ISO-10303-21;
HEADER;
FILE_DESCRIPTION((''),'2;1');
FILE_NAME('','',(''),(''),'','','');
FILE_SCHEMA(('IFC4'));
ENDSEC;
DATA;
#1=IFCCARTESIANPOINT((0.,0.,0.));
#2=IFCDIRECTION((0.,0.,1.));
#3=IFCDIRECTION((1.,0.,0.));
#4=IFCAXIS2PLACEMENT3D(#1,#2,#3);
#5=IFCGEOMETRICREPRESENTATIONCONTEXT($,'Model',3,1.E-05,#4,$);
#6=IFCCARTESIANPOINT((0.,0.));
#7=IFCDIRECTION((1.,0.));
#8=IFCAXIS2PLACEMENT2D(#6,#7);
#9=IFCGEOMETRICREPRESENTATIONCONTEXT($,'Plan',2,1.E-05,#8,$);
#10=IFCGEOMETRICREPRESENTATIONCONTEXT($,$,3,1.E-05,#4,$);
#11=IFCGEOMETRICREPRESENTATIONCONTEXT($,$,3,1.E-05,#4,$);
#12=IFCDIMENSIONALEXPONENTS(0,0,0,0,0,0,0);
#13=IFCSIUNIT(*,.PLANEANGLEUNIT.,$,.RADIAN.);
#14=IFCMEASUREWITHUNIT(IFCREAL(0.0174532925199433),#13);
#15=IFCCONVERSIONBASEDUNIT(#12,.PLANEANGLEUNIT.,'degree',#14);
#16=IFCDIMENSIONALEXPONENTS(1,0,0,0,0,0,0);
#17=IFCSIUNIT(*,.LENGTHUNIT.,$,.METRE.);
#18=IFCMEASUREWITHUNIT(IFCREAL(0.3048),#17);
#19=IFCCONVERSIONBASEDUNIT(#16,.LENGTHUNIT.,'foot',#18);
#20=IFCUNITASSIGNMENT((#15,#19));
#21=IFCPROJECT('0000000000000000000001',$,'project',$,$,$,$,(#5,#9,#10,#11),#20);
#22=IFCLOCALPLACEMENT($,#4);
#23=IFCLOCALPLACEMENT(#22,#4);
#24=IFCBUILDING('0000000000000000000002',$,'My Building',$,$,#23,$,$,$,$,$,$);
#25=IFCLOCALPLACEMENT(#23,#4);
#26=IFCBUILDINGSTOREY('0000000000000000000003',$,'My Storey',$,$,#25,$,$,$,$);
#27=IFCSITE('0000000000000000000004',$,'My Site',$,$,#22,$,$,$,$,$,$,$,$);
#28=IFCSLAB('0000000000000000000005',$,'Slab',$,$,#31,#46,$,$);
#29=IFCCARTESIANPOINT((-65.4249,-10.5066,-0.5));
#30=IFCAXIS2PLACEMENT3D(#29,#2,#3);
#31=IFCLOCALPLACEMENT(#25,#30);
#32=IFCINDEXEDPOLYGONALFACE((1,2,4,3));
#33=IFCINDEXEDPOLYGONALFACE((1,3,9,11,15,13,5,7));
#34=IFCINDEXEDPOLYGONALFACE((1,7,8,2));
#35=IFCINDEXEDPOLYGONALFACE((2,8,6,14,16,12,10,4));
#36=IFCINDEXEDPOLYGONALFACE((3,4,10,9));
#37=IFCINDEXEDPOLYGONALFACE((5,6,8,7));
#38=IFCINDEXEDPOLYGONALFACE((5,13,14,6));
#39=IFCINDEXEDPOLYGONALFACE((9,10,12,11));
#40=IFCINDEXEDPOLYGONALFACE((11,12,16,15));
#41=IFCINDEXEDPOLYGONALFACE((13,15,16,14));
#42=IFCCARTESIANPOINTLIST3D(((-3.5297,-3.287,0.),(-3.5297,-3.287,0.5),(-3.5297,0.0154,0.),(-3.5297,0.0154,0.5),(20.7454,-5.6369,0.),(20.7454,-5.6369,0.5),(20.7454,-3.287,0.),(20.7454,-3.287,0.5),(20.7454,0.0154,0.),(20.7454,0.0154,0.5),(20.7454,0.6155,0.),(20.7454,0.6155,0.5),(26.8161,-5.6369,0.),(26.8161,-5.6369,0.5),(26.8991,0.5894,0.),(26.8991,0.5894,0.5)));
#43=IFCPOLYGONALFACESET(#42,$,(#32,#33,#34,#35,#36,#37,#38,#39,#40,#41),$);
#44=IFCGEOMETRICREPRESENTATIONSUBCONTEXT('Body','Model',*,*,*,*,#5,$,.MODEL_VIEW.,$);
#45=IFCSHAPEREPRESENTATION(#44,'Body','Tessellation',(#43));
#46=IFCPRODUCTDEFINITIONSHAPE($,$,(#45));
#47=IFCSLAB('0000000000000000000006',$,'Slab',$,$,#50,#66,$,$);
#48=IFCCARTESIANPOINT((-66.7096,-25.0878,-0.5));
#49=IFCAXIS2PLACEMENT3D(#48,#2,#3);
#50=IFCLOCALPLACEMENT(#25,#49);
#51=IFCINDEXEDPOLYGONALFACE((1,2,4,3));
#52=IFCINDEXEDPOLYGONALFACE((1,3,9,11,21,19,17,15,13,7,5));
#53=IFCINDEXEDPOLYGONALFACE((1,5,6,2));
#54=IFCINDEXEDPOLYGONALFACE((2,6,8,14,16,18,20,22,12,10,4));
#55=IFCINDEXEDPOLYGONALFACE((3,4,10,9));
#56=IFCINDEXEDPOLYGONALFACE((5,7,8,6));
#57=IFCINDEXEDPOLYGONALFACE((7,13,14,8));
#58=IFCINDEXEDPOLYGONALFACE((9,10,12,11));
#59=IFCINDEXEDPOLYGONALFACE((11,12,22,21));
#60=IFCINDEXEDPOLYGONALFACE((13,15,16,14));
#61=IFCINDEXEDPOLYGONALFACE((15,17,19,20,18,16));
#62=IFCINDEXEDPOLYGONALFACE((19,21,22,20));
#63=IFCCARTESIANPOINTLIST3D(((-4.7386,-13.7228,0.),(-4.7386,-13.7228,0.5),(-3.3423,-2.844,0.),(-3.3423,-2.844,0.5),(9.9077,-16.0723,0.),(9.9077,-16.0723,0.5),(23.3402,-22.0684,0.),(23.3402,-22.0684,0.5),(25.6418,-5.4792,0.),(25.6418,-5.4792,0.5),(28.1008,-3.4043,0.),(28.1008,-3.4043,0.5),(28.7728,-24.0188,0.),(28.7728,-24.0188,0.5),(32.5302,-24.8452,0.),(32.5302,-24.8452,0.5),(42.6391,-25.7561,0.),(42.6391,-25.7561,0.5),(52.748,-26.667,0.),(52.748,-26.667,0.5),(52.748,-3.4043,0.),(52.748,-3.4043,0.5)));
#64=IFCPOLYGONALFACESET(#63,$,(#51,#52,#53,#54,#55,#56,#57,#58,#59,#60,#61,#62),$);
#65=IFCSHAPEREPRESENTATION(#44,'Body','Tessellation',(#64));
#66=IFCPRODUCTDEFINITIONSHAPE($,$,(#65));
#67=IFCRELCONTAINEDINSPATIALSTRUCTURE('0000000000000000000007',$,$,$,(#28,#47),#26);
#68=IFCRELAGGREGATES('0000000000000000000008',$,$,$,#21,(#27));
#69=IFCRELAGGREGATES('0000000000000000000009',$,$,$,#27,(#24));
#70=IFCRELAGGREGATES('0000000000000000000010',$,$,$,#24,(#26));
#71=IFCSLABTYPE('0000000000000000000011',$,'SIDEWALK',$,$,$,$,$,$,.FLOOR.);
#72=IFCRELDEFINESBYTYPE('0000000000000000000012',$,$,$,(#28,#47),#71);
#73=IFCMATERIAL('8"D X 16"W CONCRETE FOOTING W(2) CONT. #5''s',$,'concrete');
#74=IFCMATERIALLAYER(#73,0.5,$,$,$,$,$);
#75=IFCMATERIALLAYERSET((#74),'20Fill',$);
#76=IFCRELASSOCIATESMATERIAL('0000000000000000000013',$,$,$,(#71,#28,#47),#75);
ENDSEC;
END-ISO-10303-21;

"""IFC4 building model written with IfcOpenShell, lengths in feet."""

from ifc_helpers import new_model, entity, si_unit, converted_unit, frame, origin_with_axes, origin_2d_with_axis, place, context, subcontext, project, spatial, line, indexed_curve, outline, extrude, material, layer, layer_set, layer_usage, type_object, element, save


model = new_model("IFC4")

# Units and contexts
model_context = context("Model", 3, precision=1e-05, world=origin_with_axes())
plan_context = context("Plan", 2, precision=1e-05, world=origin_2d_with_axis())
context_of_model_1 = context(None, 3, precision=1e-05, world=origin_with_axes())
context_of_model_2 = context(None, 3, precision=1e-05, world=origin_with_axes())
body_context = subcontext(model_context, "Body", "Model", "MODEL_VIEW")
ifc_project = project(units=[converted_unit("PLANEANGLEUNIT", "degree", entity("IfcReal", 0.0174532925199433), si_unit("PLANEANGLEUNIT", "RADIAN"), dimensions=[0, 0, 0, 0, 0, 0, 0]), converted_unit("LENGTHUNIT", "foot", entity("IfcReal", 0.3048), si_unit("LENGTHUNIT", "METRE"), dimensions=[1, 0, 0, 0, 0, 0, 0])], contexts=[model_context, plan_context, context_of_model_1, context_of_model_2])

# Site, building, storey
site_placement = place(None, origin_with_axes())
site = spatial("IfcSite", under=ifc_project, at=site_placement, Name="My Site")
building_placement = place(site_placement, origin_with_axes())
building = spatial("IfcBuilding", under=site, at=building_placement, Name="My Building")
storey_placement = place(building_placement, origin_with_axes())
storey = spatial("IfcBuildingStorey", under=building, at=storey_placement, Name="My Storey")

# Slabs
ifc_material_1 = material(Name="8\"D X 16\"W CONCRETE FOOTING W(2) CONT. #5's", Category="concrete")
ifc_layer_1 = layer(ifc_material_1, 0.5)
ifc_layer_set_1 = layer_set([ifc_layer_1], Name="20Fill")
ifc_layer_usage_1 = layer_usage(ifc_layer_set_1, "AXIS3", "POSITIVE", 0.0)
slab_type_1 = type_object("IfcSlabType", Name="SIDEWALK", PredefinedType="FLOOR", material=ifc_layer_set_1)
slab_1_placement = place(storey_placement, frame((-65.4249, -10.5066, -0.5), z_axis=(0.0, 0.0, 1.0), x_axis=(1.0, 0.0, 0.0)))
element("IfcSlab", 1, at=slab_1_placement, inside=storey, type_object=slab_type_1, material=ifc_layer_usage_1, Name="Slab", context=body_context, shape_type="SweptSolid", body=[
    extrude(outline(indexed_curve([(-3.5297, 0.0154), (20.7454, 0.0154), (20.7454, 0.6155), (26.8991, 0.5894), (26.8161, -5.6369), (20.7454, -5.6369), (20.7454, -3.287), (-3.5297, -3.287)], segments=[line(5, 6), line(6, 7), line(7, 8), line(8, 1), line(1, 2), line(2, 3), line(3, 4), line(4, 5)], self_intersect=False)), None, (0.0, 0.0, 1.0), 0.5),
])
ifc_layer_usage_2 = layer_usage(ifc_layer_set_1, "AXIS3", "POSITIVE", 0.0)
slab_2_placement = place(storey_placement, frame((-66.7096, -25.0878, -0.5), z_axis=(0.0, 0.0, 1.0), x_axis=(1.0, 0.0, 0.0)))
element("IfcSlab", 2, at=slab_2_placement, inside=storey, type_object=slab_type_1, material=ifc_layer_usage_2, Name="Slab", context=body_context, shape_type="SweptSolid", body=[
    extrude(outline(indexed_curve([(23.3402, -22.0684), (9.9077, -16.0723), (-4.7386, -13.7228), (-3.3423, -2.844), (28.1008, -3.4043), (52.748, -3.4043), (52.748, -26.667), (25.6418, -5.4792), (28.7728, -24.0188), (32.5302, -24.8452), (42.6391, -25.7561)], segments=[line(5, 8), line(8, 4), line(4, 3), line(3, 2), line(2, 1), line(1, 9), line(9, 10), line(10, 11), line(11, 7), line(7, 6), line(6, 5)], self_intersect=False)), None, (0.0, 0.0, 1.0), 0.5),
])

save(model, "model.ifc")
